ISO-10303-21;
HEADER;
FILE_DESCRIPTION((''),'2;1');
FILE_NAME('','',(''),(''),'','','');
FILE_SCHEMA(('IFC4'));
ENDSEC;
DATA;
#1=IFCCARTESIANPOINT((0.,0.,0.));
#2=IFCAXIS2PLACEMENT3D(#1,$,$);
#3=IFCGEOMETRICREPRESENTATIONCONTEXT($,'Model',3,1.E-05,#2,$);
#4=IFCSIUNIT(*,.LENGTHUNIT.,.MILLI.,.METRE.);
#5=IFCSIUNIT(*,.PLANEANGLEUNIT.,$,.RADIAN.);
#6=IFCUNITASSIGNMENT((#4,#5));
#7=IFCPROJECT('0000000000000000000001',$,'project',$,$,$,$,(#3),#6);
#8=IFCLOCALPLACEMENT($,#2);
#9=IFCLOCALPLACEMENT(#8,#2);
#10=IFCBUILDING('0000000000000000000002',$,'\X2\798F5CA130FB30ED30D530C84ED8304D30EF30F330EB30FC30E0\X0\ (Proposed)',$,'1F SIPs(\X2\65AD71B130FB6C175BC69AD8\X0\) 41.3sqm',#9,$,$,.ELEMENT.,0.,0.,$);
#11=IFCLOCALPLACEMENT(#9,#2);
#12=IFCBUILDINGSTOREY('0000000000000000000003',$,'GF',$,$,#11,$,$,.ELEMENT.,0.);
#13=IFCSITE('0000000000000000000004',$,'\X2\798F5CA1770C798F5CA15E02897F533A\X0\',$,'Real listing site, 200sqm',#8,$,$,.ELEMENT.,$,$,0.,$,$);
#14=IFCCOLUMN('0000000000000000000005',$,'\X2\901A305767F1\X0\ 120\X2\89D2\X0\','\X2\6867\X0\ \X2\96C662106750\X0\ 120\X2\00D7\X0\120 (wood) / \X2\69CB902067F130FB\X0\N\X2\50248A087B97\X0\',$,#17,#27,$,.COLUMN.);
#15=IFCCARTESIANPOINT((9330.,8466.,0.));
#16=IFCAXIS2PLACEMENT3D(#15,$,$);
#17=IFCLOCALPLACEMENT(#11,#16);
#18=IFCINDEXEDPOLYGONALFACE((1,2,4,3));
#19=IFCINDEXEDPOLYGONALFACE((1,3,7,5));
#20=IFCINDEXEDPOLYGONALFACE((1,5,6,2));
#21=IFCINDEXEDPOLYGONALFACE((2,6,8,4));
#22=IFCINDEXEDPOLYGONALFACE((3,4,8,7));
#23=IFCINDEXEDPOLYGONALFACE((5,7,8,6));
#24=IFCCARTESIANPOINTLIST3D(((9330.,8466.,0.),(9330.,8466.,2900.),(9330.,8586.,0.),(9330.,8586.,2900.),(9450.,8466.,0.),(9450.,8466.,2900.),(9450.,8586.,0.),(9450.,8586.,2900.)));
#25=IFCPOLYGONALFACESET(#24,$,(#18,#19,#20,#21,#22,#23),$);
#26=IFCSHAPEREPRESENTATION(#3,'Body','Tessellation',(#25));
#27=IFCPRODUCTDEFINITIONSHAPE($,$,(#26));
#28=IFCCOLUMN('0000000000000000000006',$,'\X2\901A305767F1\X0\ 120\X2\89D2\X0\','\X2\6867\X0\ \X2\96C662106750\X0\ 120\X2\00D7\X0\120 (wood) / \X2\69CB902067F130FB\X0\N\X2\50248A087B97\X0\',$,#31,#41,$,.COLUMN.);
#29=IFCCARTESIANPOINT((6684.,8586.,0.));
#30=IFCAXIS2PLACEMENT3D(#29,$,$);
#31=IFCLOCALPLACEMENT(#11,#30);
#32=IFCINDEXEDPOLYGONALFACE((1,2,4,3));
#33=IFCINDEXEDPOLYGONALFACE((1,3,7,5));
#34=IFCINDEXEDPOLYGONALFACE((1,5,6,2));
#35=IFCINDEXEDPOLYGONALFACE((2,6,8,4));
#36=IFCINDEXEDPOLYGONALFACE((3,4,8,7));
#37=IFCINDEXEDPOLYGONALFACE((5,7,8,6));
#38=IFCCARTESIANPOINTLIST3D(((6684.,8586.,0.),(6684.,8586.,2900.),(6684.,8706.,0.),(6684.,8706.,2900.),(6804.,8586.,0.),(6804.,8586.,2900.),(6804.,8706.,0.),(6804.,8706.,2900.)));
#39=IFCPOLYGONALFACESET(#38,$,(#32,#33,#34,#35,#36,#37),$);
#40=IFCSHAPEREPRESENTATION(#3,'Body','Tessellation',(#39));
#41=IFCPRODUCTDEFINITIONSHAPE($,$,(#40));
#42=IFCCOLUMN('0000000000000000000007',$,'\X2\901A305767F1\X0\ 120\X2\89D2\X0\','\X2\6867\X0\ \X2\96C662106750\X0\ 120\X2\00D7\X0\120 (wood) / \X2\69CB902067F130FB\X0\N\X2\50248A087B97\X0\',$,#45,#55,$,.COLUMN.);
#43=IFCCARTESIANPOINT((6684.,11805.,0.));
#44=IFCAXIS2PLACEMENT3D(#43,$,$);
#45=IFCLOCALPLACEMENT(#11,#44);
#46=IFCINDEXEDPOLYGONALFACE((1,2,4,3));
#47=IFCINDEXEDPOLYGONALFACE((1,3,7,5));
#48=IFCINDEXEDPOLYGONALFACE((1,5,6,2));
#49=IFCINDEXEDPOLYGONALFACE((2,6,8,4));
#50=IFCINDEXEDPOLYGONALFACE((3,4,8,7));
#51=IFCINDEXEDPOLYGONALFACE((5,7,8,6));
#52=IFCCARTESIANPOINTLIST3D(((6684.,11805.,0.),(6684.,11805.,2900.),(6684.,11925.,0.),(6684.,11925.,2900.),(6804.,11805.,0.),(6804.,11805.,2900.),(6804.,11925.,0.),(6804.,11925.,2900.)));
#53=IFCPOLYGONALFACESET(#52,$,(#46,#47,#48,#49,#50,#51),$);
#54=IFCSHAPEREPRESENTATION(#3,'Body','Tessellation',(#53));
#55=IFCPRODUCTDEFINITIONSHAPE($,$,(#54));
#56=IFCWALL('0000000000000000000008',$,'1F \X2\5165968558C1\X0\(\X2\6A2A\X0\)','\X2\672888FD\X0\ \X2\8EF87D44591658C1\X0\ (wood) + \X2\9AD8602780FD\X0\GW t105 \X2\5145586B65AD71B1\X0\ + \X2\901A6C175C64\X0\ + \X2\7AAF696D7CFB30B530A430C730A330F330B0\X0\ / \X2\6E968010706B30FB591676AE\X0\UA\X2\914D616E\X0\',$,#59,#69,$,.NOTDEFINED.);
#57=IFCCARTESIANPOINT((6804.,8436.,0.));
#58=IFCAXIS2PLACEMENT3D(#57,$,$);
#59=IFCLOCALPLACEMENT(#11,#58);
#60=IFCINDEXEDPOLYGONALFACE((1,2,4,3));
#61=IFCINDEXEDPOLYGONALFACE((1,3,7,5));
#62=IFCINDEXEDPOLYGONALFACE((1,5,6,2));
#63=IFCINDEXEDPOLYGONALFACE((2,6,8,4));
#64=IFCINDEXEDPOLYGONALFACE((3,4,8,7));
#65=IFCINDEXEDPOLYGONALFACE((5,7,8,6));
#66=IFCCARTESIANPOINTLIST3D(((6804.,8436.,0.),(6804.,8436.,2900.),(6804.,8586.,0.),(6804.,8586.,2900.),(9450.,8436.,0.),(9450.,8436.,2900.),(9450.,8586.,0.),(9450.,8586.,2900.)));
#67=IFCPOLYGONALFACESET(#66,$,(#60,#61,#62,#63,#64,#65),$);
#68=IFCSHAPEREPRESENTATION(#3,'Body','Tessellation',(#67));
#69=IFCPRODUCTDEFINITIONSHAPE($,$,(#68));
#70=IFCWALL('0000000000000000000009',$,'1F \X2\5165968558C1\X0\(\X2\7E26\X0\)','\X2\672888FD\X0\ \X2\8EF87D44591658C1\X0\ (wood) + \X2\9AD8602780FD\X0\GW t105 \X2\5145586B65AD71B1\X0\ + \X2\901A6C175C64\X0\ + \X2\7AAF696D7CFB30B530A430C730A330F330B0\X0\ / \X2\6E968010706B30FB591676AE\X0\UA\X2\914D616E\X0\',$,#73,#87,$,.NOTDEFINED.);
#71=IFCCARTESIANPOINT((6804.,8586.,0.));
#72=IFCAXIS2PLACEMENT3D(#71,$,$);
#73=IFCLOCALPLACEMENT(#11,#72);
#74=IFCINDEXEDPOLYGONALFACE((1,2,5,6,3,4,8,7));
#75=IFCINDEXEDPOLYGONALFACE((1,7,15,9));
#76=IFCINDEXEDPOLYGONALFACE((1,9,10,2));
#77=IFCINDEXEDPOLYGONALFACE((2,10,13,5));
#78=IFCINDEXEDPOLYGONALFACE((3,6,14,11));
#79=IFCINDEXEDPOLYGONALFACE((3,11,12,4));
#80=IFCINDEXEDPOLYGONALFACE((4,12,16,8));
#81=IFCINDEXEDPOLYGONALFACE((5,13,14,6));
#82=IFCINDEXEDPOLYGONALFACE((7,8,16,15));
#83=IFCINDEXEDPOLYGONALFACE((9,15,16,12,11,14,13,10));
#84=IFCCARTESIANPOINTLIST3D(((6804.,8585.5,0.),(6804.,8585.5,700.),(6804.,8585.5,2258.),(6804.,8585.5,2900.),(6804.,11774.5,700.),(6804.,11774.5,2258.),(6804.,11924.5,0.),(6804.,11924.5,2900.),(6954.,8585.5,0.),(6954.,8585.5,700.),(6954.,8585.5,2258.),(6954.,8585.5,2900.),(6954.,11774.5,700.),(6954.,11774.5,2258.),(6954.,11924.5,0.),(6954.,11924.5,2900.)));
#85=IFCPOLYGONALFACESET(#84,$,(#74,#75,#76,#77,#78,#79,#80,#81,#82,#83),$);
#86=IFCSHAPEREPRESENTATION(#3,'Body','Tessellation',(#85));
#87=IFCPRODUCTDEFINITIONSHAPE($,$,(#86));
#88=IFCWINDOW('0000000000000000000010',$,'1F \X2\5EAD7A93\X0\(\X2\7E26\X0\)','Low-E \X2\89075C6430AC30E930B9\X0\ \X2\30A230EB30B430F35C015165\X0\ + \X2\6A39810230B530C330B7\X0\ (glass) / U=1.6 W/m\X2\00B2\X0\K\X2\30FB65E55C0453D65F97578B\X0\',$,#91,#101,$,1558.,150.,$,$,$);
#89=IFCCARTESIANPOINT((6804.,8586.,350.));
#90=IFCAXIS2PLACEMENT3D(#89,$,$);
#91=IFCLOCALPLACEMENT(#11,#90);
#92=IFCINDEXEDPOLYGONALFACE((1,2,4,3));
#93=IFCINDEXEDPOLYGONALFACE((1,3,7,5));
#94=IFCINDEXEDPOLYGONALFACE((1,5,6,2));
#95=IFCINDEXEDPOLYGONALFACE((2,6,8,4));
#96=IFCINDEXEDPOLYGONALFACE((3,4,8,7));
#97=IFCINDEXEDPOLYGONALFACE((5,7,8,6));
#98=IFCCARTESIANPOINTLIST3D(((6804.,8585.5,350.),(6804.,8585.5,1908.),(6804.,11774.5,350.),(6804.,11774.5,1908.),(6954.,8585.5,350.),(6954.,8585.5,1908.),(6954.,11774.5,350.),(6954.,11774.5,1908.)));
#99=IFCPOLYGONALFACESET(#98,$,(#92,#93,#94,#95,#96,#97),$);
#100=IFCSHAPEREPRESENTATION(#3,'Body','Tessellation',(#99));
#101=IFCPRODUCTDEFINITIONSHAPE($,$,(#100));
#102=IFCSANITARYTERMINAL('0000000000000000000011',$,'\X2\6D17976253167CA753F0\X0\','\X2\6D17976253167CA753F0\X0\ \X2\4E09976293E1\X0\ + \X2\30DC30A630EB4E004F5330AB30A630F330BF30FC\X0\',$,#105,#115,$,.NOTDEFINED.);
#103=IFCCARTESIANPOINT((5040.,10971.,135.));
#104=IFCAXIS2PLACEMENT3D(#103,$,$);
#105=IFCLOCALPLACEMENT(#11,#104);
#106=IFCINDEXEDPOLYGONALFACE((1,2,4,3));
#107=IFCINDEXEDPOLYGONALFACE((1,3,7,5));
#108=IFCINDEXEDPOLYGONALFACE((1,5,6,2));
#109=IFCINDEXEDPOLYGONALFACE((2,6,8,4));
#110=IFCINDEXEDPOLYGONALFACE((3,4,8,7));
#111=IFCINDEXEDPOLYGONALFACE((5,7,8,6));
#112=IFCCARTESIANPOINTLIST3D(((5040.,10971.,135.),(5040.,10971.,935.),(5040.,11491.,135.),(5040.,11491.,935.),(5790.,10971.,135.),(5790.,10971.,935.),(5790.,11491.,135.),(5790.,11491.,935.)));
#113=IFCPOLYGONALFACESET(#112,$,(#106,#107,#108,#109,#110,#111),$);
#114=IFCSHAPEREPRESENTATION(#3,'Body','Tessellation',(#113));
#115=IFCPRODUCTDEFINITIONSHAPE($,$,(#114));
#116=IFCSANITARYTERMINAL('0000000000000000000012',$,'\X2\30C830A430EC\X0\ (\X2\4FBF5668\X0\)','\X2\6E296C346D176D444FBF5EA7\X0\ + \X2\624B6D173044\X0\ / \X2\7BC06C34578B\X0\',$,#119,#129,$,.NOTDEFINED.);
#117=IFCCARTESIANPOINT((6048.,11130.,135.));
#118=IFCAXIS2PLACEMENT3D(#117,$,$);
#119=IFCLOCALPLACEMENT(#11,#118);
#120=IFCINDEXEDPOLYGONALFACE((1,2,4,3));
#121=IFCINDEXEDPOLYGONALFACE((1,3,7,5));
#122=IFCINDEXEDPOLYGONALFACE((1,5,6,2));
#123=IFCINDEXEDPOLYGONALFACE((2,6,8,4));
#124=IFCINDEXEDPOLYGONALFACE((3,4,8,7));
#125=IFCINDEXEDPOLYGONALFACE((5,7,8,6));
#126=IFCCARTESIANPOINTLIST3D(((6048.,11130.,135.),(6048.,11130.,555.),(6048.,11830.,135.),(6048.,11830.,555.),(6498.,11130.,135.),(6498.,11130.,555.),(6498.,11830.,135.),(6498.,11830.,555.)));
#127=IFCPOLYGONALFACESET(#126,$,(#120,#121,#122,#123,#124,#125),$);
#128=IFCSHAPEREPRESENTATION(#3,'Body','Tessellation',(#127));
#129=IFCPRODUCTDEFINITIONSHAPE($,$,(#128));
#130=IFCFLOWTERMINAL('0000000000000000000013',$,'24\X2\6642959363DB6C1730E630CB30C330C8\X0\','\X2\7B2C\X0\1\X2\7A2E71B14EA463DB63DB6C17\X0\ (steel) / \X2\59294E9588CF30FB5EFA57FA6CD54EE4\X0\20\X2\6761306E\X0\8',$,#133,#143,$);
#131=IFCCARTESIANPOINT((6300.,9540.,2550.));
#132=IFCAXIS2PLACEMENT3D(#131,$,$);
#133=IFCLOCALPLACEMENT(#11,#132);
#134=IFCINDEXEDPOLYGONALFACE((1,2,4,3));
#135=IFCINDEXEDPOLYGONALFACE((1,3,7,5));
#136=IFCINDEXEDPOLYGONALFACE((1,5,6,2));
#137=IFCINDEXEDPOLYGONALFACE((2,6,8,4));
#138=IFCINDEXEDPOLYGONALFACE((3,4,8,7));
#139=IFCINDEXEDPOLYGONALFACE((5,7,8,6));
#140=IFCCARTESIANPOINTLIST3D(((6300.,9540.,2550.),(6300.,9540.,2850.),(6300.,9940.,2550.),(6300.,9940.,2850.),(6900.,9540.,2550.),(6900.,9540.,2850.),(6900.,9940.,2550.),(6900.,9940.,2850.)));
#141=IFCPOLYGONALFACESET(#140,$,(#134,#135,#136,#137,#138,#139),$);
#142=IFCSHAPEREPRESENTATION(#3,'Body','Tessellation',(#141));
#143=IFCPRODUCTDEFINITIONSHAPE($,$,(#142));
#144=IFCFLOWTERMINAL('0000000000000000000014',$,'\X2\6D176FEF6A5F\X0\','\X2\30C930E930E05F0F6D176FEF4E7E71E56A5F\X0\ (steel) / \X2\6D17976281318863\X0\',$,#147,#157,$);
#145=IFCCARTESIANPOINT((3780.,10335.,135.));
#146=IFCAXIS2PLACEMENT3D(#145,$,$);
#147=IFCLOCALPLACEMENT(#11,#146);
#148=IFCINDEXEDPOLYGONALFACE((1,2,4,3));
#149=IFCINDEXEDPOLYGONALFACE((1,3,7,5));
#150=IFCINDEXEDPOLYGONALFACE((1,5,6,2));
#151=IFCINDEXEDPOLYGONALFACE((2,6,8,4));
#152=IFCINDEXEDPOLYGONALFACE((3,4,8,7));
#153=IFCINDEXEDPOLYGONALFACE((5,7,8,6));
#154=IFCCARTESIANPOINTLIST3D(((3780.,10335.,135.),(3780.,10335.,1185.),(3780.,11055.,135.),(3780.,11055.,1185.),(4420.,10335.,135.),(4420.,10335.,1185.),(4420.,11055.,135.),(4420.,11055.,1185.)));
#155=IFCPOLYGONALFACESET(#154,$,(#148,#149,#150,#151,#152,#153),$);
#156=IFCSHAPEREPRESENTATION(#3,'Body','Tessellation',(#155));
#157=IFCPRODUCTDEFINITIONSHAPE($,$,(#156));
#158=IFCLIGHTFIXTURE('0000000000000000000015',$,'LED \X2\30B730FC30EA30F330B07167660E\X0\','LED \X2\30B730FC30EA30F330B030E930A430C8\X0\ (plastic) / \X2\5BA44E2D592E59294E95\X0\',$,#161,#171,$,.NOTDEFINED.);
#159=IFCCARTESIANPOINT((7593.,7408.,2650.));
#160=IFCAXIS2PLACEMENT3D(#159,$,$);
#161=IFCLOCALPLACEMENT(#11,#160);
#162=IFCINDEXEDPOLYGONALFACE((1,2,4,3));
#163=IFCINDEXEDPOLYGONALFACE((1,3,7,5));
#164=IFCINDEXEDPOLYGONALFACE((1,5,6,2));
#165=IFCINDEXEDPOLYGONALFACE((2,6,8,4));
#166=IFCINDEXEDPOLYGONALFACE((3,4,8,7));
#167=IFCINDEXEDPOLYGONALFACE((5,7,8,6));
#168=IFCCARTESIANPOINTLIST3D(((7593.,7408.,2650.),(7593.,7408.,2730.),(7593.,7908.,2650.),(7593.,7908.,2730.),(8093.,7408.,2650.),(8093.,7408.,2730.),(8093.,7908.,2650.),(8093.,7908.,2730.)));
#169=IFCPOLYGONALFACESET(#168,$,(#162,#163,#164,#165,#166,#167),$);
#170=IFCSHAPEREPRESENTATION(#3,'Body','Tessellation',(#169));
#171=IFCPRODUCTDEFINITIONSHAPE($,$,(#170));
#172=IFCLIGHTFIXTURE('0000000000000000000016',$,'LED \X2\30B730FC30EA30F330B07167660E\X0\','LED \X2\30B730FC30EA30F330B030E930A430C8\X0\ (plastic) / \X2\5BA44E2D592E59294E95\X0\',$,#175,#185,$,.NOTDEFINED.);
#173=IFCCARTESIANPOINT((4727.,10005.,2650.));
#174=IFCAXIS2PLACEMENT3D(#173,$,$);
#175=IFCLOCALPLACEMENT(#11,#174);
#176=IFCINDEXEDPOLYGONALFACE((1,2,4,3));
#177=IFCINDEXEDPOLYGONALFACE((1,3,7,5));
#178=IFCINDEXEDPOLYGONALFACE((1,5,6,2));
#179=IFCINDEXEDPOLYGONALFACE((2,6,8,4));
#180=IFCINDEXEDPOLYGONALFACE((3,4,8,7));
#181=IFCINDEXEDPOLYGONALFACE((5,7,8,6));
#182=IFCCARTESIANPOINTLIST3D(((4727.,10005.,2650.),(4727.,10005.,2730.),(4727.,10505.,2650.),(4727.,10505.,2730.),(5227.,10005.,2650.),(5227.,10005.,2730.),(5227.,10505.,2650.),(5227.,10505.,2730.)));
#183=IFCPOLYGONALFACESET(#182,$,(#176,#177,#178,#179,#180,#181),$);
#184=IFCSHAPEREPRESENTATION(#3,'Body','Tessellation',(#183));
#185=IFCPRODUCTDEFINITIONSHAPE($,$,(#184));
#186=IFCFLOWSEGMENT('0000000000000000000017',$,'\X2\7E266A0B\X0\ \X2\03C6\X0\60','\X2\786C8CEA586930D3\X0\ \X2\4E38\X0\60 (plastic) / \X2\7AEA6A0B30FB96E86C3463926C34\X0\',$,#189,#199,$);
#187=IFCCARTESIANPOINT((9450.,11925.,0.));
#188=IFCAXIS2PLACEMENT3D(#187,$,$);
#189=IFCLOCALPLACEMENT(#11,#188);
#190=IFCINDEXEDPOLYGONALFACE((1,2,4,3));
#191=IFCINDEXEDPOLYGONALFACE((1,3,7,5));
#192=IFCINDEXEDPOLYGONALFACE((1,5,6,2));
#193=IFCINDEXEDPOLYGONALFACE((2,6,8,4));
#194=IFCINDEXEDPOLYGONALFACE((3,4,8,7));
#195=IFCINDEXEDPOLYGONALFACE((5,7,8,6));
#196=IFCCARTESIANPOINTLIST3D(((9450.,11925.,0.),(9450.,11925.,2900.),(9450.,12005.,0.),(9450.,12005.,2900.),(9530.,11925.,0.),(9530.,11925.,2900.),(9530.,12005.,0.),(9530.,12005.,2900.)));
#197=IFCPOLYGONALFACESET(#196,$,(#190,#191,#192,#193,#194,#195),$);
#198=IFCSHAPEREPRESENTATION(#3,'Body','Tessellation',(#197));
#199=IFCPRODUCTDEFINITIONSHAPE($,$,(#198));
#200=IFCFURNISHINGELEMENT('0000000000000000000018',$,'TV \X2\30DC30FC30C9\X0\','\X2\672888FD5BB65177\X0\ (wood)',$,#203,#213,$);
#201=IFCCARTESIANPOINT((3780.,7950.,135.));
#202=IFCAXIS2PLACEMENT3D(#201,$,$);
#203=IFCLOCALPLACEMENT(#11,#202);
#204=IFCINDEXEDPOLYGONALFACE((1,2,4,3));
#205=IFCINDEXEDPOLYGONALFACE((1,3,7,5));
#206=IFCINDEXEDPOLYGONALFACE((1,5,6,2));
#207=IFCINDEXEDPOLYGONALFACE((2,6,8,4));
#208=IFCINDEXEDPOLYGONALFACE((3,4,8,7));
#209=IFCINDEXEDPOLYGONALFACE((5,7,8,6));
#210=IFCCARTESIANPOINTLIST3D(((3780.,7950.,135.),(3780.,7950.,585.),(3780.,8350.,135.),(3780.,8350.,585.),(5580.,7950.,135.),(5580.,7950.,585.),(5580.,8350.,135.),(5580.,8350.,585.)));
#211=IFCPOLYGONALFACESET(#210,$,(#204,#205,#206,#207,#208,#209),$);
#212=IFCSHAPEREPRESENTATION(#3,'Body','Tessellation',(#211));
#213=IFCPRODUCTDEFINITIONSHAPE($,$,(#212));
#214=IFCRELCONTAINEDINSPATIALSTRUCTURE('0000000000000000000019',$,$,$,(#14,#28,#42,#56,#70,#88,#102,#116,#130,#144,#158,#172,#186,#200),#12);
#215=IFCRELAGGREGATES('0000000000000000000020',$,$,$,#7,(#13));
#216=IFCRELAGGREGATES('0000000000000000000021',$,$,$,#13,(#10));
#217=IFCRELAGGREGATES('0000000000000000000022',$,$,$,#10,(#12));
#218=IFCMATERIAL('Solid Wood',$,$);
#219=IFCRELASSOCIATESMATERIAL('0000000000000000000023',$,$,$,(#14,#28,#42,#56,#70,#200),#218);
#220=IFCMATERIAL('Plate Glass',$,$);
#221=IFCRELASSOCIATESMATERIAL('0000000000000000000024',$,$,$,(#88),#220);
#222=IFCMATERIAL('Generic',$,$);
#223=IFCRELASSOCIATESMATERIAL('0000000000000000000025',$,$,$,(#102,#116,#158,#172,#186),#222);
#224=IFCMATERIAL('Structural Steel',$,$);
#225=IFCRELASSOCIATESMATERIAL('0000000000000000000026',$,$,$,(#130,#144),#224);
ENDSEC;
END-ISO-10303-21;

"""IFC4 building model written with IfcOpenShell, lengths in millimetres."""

from ifc_helpers import new_model, si_unit, frame, frame_2d, origin, place, context, project, spatial, rectangle, extrude, material, element, fill, save


model = new_model("IFC4")

# Units and contexts
model_context = context("Model", 3, precision=1e-05, world=origin())
ifc_project = project(units=[si_unit("LENGTHUNIT", "METRE", prefix="MILLI"), si_unit("PLANEANGLEUNIT", "RADIAN")], contexts=[model_context])

# Site, building, storey
site_placement = place(None, origin())
site = spatial("IfcSite", under=ifc_project, at=site_placement, Name="福岡県福岡市西区", ObjectType="Real listing site, 200sqm", CompositionType="ELEMENT", RefElevation=0.0)
building_placement = place(site_placement, origin())
building = spatial("IfcBuilding", under=site, at=building_placement, Name="福岡・ロフト付きワンルーム (Proposed)", ObjectType="1F SIPs(断熱・気密高) 41.3sqm", CompositionType="ELEMENT", ElevationOfRefHeight=0.0, ElevationOfTerrain=0.0)
storey_placement = place(building_placement, origin())
storey = spatial("IfcBuildingStorey", under=building, at=storey_placement, Name="GF", CompositionType="ELEMENT", Elevation=0.0)

# Columns
ifc_material_1 = material(Name="Solid Wood")
column_1_placement = place(storey_placement, frame((9330.0, 8466.0, 0.0)))
element("IfcColumn", 1, at=column_1_placement, inside=storey, material=ifc_material_1, Name="通し柱 120角", Description="桧 集成材 120×120 (wood) / 構造柱・N値計算", PredefinedType="COLUMN", context=model_context, shape_type="SweptSolid", body=[
    extrude(rectangle(XDim=120.0, YDim=120.0, at=frame_2d((60.0, 60.0))), frame((9330.0, 8466.0, 0.0)), (0.0, 0.0, 1.0), 2900.0),
])
column_2_placement = place(storey_placement, frame((6684.0, 8586.0, 0.0)))
element("IfcColumn", 2, at=column_2_placement, inside=storey, material=ifc_material_1, Name="通し柱 120角", Description="桧 集成材 120×120 (wood) / 構造柱・N値計算", PredefinedType="COLUMN", context=model_context, shape_type="SweptSolid", body=[
    extrude(rectangle(XDim=120.0, YDim=120.0, at=frame_2d((60.0, 60.0))), frame((6684.0, 8586.0, 0.0)), (0.0, 0.0, 1.0), 2900.0),
])
column_3_placement = place(storey_placement, frame((6684.0, 11805.0, 0.0)))
element("IfcColumn", 3, at=column_3_placement, inside=storey, material=ifc_material_1, Name="通し柱 120角", Description="桧 集成材 120×120 (wood) / 構造柱・N値計算", PredefinedType="COLUMN", context=model_context, shape_type="SweptSolid", body=[
    extrude(rectangle(XDim=120.0, YDim=120.0, at=frame_2d((60.0, 60.0))), frame((6684.0, 11805.0, 0.0)), (0.0, 0.0, 1.0), 2900.0),
])

# Wall
wall_1_placement = place(storey_placement, frame((6804.0, 8436.0, 0.0)))
element("IfcWall", 4, at=wall_1_placement, inside=storey, material=ifc_material_1, Name="1F 入隅壁(横)", Description="木製 軸組外壁 (wood) + 高性能GW t105 充填断熱 + 通気層 + 窯業系サイディング / 準耐火・外皮UA配慮", PredefinedType="NOTDEFINED", context=model_context, shape_type="SweptSolid", body=[
    extrude(rectangle(XDim=2646.0, YDim=150.0, at=frame_2d((1323.0, 75.0))), frame((6804.0, 8436.0, 0.0)), (0.0, 0.0, 1.0), 2900.0),
])

# Wall, opening, window
wall_2_placement = place(storey_placement, frame((6804.0, 8586.0, 0.0)))
wall_2 = element("IfcWall", 5, at=wall_2_placement, inside=storey, material=ifc_material_1, Name="1F 入隅壁(縦)", Description="木製 軸組外壁 (wood) + 高性能GW t105 充填断熱 + 通気層 + 窯業系サイディング / 準耐火・外皮UA配慮", PredefinedType="NOTDEFINED", context=model_context, shape_type="SweptSolid", body=[
    extrude(rectangle(XDim=150.0, YDim=3339.0, at=frame_2d((75.0, 1669.0))), frame((6804.0, 8586.0, 0.0)), (0.0, 0.0, 1.0), 2900.0),
])
opening_placement = place(storey_placement, frame((6804.0, 8586.0, 350.0)))
opening = element("IfcOpeningElement", 6, at=opening_placement, cuts=wall_2, PredefinedType="NOTDEFINED", context=model_context, shape_type="SweptSolid", body=[
    extrude(rectangle(XDim=150.0, YDim=3189.0, at=frame_2d((75.0, 1594.0))), frame((6804.0, 8586.0, 350.0)), (0.0, 0.0, 1.0), 1558.0),
])
ifc_material_2 = material(Name="Plate Glass")
window_placement = place(storey_placement, frame((6804.0, 8586.0, 350.0)))
window = element("IfcWindow", 7, at=window_placement, inside=storey, material=ifc_material_2, Name="1F 庭窓(縦)", Description="Low-E 複層ガラス アルゴン封入 + 樹脂サッシ (glass) / U=1.6 W/m²K・日射取得型", OverallHeight=1558.0, OverallWidth=150.0, context=model_context, shape_type="SweptSolid", body=[
    extrude(rectangle(XDim=150.0, YDim=3189.0, at=frame_2d((75.0, 1594.0))), frame((6804.0, 8586.0, 350.0)), (0.0, 0.0, 1.0), 1558.0),
])
fill(opening, window)

# Sanitary terminals
ifc_material_3 = material(Name="Generic")
sanitary_terminal_1_placement = place(storey_placement, frame((5040.0, 10971.0, 135.0)))
element("IfcSanitaryTerminal", 8, at=sanitary_terminal_1_placement, inside=storey, material=ifc_material_3, Name="洗面化粧台", Description="洗面化粧台 三面鏡 + ボウル一体カウンター", PredefinedType="NOTDEFINED", context=model_context, shape_type="SweptSolid", body=[
    extrude(rectangle(XDim=750.0, YDim=520.0, at=frame_2d((375.0, 260.0))), frame((5040.0, 10971.0, 135.0)), (0.0, 0.0, 1.0), 800.0),
])
sanitary_terminal_2_placement = place(storey_placement, frame((6048.0, 11130.0, 135.0)))
element("IfcSanitaryTerminal", 9, at=sanitary_terminal_2_placement, inside=storey, material=ifc_material_3, Name="トイレ (便器)", Description="温水洗浄便座 + 手洗い / 節水型", PredefinedType="NOTDEFINED", context=model_context, shape_type="SweptSolid", body=[
    extrude(rectangle(XDim=450.0, YDim=700.0, at=frame_2d((225.0, 350.0))), frame((6048.0, 11130.0, 135.0)), (0.0, 0.0, 1.0), 420.0),
])

# Flow terminals
ifc_material_4 = material(Name="Structural Steel")
flow_terminal_1_placement = place(storey_placement, frame((6300.0, 9540.0, 2550.0)))
element("IfcFlowTerminal", 10, at=flow_terminal_1_placement, inside=storey, material=ifc_material_4, Name="24時間換気ユニット", Description="第1種熱交換換気 (steel) / 天井裏・建基法令20条の8", context=model_context, shape_type="SweptSolid", body=[
    extrude(rectangle(XDim=600.0, YDim=400.0, at=frame_2d((300.0, 200.0))), frame((6300.0, 9540.0, 2550.0)), (0.0, 0.0, 1.0), 300.0),
])
flow_terminal_2_placement = place(storey_placement, frame((3780.0, 10335.0, 135.0)))
element("IfcFlowTerminal", 11, at=flow_terminal_2_placement, inside=storey, material=ifc_material_4, Name="洗濯機", Description="ドラム式洗濯乾燥機 (steel) / 洗面脱衣", context=model_context, shape_type="SweptSolid", body=[
    extrude(rectangle(XDim=640.0, YDim=720.0, at=frame_2d((320.0, 360.0))), frame((3780.0, 10335.0, 135.0)), (0.0, 0.0, 1.0), 1050.0),
])

# Light fixtures
light_fixture_1_placement = place(storey_placement, frame((7593.0, 7408.0, 2650.0)))
element("IfcLightFixture", 12, at=light_fixture_1_placement, inside=storey, material=ifc_material_3, Name="LED シーリング照明", Description="LED シーリングライト (plastic) / 室中央天井", PredefinedType="NOTDEFINED", context=model_context, shape_type="SweptSolid", body=[
    extrude(rectangle(XDim=500.0, YDim=500.0, at=frame_2d((250.0, 250.0))), frame((7593.0, 7408.0, 2650.0)), (0.0, 0.0, 1.0), 80.0),
])
light_fixture_2_placement = place(storey_placement, frame((4727.0, 10005.0, 2650.0)))
element("IfcLightFixture", 13, at=light_fixture_2_placement, inside=storey, material=ifc_material_3, Name="LED シーリング照明", Description="LED シーリングライト (plastic) / 室中央天井", PredefinedType="NOTDEFINED", context=model_context, shape_type="SweptSolid", body=[
    extrude(rectangle(XDim=500.0, YDim=500.0, at=frame_2d((250.0, 250.0))), frame((4727.0, 10005.0, 2650.0)), (0.0, 0.0, 1.0), 80.0),
])

# Flow segment
flow_segment_placement = place(storey_placement, frame((9450.0, 11925.0, 0.0)))
element("IfcFlowSegment", 14, at=flow_segment_placement, inside=storey, material=ifc_material_3, Name="縦樋 φ60", Description="硬質塩ビ 丸60 (plastic) / 竪樋・雨水排水", context=model_context, shape_type="SweptSolid", body=[
    extrude(rectangle(XDim=80.0, YDim=80.0, at=frame_2d((40.0, 40.0))), frame((9450.0, 11925.0, 0.0)), (0.0, 0.0, 1.0), 2900.0),
])

# Furnishing element
furnishing_placement = place(storey_placement, frame((3780.0, 7950.0, 135.0)))
element("IfcFurnishingElement", 15, at=furnishing_placement, inside=storey, material=ifc_material_1, Name="TV ボード", Description="木製家具 (wood)", context=model_context, shape_type="SweptSolid", body=[
    extrude(rectangle(XDim=1800.0, YDim=400.0, at=frame_2d((900.0, 200.0))), frame((3780.0, 7950.0, 135.0)), (0.0, 0.0, 1.0), 450.0),
])

save(model, "model.ifc")
